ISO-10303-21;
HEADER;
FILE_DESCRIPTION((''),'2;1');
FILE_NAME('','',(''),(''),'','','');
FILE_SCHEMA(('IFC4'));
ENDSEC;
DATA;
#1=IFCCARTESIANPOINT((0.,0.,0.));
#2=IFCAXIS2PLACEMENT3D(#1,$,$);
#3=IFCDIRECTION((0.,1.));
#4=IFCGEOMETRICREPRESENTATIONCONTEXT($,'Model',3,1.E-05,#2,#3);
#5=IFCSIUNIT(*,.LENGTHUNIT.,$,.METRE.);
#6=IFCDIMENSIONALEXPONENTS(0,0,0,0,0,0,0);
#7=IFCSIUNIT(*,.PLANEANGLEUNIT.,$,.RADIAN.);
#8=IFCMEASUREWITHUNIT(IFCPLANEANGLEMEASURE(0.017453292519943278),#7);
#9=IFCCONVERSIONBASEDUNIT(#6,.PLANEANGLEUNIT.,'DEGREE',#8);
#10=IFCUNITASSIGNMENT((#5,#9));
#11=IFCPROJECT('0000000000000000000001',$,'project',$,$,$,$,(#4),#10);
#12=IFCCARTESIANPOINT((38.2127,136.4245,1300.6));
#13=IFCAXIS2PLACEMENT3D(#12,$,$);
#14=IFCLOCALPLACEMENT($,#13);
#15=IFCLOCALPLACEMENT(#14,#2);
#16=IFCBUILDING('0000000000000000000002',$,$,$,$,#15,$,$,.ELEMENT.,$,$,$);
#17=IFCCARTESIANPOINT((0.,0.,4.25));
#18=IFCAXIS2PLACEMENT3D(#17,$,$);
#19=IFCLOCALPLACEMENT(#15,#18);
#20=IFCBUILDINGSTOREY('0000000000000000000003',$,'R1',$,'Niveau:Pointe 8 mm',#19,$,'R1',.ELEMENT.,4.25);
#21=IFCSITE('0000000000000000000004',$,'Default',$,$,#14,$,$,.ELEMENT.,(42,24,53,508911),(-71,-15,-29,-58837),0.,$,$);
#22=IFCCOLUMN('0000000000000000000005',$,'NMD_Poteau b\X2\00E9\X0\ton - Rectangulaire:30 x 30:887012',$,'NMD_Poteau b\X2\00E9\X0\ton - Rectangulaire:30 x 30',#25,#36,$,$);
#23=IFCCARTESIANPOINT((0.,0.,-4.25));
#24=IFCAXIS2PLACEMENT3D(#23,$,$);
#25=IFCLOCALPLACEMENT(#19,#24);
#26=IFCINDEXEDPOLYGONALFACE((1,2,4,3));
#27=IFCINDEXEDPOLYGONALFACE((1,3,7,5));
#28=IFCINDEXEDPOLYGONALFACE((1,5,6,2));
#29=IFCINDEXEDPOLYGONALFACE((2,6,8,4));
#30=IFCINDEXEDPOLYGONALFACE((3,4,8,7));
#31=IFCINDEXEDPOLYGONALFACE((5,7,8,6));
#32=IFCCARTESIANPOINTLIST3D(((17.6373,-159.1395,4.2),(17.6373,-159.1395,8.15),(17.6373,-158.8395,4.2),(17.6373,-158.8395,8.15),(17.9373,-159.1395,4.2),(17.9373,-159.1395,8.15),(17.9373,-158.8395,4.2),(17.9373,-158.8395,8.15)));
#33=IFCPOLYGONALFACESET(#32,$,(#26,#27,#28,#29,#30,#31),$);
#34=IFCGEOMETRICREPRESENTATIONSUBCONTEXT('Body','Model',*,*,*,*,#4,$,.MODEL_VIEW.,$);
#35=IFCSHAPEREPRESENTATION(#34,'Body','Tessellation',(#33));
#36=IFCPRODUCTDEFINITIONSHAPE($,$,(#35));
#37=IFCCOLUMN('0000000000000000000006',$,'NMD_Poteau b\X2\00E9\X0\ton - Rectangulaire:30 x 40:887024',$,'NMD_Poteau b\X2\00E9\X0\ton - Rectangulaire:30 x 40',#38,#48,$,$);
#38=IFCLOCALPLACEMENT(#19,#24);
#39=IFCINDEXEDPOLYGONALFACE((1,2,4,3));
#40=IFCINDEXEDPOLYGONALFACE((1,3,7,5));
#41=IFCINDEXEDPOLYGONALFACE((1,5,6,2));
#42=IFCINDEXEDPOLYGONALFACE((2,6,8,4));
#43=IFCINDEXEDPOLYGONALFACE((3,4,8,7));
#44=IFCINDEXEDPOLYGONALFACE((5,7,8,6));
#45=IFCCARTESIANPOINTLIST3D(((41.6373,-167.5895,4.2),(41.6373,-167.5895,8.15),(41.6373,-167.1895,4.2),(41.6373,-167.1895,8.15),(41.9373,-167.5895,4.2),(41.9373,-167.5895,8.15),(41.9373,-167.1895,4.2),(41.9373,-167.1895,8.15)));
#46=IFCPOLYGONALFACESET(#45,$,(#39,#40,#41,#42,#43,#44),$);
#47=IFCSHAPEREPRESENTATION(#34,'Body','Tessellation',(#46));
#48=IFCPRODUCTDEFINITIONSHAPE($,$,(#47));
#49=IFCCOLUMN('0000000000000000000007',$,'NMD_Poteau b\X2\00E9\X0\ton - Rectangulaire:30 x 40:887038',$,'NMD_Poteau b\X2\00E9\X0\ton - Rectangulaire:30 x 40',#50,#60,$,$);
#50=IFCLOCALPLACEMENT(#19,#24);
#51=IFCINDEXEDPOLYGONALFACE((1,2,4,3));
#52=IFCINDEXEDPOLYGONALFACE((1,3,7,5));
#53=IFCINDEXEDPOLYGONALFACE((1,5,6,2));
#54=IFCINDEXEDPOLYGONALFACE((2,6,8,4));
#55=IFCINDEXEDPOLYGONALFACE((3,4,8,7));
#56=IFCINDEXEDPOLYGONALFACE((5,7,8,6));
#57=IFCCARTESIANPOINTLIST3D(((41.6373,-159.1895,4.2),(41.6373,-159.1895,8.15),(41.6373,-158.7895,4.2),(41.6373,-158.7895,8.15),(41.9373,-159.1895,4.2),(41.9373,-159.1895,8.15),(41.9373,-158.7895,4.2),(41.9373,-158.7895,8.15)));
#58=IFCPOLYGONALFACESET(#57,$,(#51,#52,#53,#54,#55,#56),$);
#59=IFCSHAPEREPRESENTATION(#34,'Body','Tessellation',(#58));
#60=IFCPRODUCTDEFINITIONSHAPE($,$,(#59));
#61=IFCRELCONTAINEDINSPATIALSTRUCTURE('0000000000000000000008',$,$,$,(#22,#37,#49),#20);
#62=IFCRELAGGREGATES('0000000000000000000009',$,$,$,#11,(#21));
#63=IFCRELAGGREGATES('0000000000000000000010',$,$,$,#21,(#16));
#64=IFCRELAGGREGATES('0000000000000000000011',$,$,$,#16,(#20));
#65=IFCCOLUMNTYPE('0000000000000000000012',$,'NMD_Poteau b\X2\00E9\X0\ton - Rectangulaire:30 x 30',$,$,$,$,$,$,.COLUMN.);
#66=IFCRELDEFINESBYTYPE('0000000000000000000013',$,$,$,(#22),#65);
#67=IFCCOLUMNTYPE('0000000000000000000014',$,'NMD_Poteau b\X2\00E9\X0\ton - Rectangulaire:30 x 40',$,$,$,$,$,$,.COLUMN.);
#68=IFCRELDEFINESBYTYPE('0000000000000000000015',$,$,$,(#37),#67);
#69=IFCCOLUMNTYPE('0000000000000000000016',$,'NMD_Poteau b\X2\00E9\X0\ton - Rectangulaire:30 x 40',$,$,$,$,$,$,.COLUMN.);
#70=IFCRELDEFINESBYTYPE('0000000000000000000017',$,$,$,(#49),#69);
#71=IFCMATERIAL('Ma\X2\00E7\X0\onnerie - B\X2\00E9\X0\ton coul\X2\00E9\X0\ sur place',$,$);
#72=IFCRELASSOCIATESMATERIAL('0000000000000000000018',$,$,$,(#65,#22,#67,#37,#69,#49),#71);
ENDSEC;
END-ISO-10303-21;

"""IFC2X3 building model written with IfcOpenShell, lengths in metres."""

from ifc_helpers import new_model, entity, si_unit, converted_unit, direction, frame, frame_2d, origin, place, context, subcontext, project, spatial, rectangle, extrude, source, transform, mapped, material, type_object, type_shapes, element, save


model = new_model("IFC2X3")

# Units and contexts
model_context = context("Model", 3, precision=1e-05, world=origin(), true_north=direction((0.0, 1.0)))
body_context = subcontext(model_context, "Body", "Model", "MODEL_VIEW")
ifc_project = project(units=[si_unit("LENGTHUNIT", "METRE"), converted_unit("PLANEANGLEUNIT", "DEGREE", entity("IfcPlaneAngleMeasure", 0.017453292519943278), si_unit("PLANEANGLEUNIT", "RADIAN"), dimensions=[0, 0, 0, 0, 0, 0, 0])], contexts=[model_context])

# Site, building, storey
site_placement = place(None, frame((38.2127, 136.4245, 1300.6)))
site = spatial("IfcSite", under=ifc_project, at=site_placement, Name="Default", CompositionType="ELEMENT", RefLatitude=(42, 24, 53, 508911), RefLongitude=(-71, -15, -29, -58837), RefElevation=0.0)
building_placement = place(site_placement, origin())
building = spatial("IfcBuilding", under=site, at=building_placement, CompositionType="ELEMENT")
storey_placement = place(building_placement, frame((0.0, 0.0, 4.25)))
storey = spatial("IfcBuildingStorey", under=building, at=storey_placement, Name="R1", ObjectType="Niveau:Pointe 8 mm", LongName="R1", CompositionType="ELEMENT", Elevation=4.25)

# Columns
ifc_material = material(Name="Maçonnerie - Béton coulé sur place")
column_type_1 = type_object("IfcColumnType", Name="NMD_Poteau béton - Rectangulaire:30 x 30", PredefinedType="COLUMN", material=ifc_material)
shared_shape_1 = source(origin(), body_context, "Body", "SweptSolid", [
    extrude(rectangle(XDim=0.3, YDim=0.3, at=frame_2d((0.0, 0.0), x_axis=(1.0, 0.0))), frame((17.7873, -158.9895, 4.2), z_axis=(0.0, 0.0, 1.0), x_axis=(-1.0, 0.0, 0.0)), (0.0, 0.0, 1.0), 3.95),
])
type_shapes(column_type_1, [shared_shape_1])
column_1_placement = place(storey_placement, frame((0.0, 0.0, -4.25)))
element("IfcColumn", 1, at=column_1_placement, inside=storey, type_object=column_type_1, material=ifc_material, Name="NMD_Poteau béton - Rectangulaire:30 x 30:887012", ObjectType="NMD_Poteau béton - Rectangulaire:30 x 30", context=body_context, shape_type="MappedRepresentation", body=[
    mapped(shared_shape_1, transform((0.0, 0.0, 0.0), scale=1.0)),
])
column_type_2 = type_object("IfcColumnType", Name="NMD_Poteau béton - Rectangulaire:30 x 40", PredefinedType="COLUMN", material=ifc_material)
shared_shape_2 = source(origin(), body_context, "Body", "SweptSolid", [
    extrude(rectangle(XDim=0.3, YDim=0.4, at=frame_2d((0.0, 0.0), x_axis=(1.0, 0.0))), frame((41.7873, -167.3895, 4.2), z_axis=(0.0, 0.0, 1.0), x_axis=(-1.0, 0.0, 0.0)), (0.0, 0.0, 1.0), 3.95),
])
type_shapes(column_type_2, [shared_shape_2])
column_2_placement = place(storey_placement, frame((0.0, 0.0, -4.25)))
element("IfcColumn", 2, at=column_2_placement, inside=storey, type_object=column_type_2, material=ifc_material, Name="NMD_Poteau béton - Rectangulaire:30 x 40:887024", ObjectType="NMD_Poteau béton - Rectangulaire:30 x 40", context=body_context, shape_type="MappedRepresentation", body=[
    mapped(shared_shape_2, transform((0.0, 0.0, 0.0), scale=1.0)),
])
column_type_3 = type_object("IfcColumnType", Name="NMD_Poteau béton - Rectangulaire:30 x 40", PredefinedType="COLUMN", material=ifc_material)
shared_shape_3 = source(origin(), body_context, "Body", "SweptSolid", [
    extrude(rectangle(XDim=0.3, YDim=0.4, at=frame_2d((0.0, 0.0), x_axis=(1.0, 0.0))), frame((41.7873, -158.9895, 4.2), z_axis=(0.0, 0.0, 1.0), x_axis=(-1.0, 0.0, 0.0)), (0.0, 0.0, 1.0), 3.95),
])
type_shapes(column_type_3, [shared_shape_3])
column_3_placement = place(storey_placement, frame((0.0, 0.0, -4.25)))
element("IfcColumn", 3, at=column_3_placement, inside=storey, type_object=column_type_3, material=ifc_material, Name="NMD_Poteau béton - Rectangulaire:30 x 40:887038", ObjectType="NMD_Poteau béton - Rectangulaire:30 x 40", context=body_context, shape_type="MappedRepresentation", body=[
    mapped(shared_shape_3, transform((0.0, 0.0, 0.0), scale=1.0)),
])

save(model, "model.ifc")
